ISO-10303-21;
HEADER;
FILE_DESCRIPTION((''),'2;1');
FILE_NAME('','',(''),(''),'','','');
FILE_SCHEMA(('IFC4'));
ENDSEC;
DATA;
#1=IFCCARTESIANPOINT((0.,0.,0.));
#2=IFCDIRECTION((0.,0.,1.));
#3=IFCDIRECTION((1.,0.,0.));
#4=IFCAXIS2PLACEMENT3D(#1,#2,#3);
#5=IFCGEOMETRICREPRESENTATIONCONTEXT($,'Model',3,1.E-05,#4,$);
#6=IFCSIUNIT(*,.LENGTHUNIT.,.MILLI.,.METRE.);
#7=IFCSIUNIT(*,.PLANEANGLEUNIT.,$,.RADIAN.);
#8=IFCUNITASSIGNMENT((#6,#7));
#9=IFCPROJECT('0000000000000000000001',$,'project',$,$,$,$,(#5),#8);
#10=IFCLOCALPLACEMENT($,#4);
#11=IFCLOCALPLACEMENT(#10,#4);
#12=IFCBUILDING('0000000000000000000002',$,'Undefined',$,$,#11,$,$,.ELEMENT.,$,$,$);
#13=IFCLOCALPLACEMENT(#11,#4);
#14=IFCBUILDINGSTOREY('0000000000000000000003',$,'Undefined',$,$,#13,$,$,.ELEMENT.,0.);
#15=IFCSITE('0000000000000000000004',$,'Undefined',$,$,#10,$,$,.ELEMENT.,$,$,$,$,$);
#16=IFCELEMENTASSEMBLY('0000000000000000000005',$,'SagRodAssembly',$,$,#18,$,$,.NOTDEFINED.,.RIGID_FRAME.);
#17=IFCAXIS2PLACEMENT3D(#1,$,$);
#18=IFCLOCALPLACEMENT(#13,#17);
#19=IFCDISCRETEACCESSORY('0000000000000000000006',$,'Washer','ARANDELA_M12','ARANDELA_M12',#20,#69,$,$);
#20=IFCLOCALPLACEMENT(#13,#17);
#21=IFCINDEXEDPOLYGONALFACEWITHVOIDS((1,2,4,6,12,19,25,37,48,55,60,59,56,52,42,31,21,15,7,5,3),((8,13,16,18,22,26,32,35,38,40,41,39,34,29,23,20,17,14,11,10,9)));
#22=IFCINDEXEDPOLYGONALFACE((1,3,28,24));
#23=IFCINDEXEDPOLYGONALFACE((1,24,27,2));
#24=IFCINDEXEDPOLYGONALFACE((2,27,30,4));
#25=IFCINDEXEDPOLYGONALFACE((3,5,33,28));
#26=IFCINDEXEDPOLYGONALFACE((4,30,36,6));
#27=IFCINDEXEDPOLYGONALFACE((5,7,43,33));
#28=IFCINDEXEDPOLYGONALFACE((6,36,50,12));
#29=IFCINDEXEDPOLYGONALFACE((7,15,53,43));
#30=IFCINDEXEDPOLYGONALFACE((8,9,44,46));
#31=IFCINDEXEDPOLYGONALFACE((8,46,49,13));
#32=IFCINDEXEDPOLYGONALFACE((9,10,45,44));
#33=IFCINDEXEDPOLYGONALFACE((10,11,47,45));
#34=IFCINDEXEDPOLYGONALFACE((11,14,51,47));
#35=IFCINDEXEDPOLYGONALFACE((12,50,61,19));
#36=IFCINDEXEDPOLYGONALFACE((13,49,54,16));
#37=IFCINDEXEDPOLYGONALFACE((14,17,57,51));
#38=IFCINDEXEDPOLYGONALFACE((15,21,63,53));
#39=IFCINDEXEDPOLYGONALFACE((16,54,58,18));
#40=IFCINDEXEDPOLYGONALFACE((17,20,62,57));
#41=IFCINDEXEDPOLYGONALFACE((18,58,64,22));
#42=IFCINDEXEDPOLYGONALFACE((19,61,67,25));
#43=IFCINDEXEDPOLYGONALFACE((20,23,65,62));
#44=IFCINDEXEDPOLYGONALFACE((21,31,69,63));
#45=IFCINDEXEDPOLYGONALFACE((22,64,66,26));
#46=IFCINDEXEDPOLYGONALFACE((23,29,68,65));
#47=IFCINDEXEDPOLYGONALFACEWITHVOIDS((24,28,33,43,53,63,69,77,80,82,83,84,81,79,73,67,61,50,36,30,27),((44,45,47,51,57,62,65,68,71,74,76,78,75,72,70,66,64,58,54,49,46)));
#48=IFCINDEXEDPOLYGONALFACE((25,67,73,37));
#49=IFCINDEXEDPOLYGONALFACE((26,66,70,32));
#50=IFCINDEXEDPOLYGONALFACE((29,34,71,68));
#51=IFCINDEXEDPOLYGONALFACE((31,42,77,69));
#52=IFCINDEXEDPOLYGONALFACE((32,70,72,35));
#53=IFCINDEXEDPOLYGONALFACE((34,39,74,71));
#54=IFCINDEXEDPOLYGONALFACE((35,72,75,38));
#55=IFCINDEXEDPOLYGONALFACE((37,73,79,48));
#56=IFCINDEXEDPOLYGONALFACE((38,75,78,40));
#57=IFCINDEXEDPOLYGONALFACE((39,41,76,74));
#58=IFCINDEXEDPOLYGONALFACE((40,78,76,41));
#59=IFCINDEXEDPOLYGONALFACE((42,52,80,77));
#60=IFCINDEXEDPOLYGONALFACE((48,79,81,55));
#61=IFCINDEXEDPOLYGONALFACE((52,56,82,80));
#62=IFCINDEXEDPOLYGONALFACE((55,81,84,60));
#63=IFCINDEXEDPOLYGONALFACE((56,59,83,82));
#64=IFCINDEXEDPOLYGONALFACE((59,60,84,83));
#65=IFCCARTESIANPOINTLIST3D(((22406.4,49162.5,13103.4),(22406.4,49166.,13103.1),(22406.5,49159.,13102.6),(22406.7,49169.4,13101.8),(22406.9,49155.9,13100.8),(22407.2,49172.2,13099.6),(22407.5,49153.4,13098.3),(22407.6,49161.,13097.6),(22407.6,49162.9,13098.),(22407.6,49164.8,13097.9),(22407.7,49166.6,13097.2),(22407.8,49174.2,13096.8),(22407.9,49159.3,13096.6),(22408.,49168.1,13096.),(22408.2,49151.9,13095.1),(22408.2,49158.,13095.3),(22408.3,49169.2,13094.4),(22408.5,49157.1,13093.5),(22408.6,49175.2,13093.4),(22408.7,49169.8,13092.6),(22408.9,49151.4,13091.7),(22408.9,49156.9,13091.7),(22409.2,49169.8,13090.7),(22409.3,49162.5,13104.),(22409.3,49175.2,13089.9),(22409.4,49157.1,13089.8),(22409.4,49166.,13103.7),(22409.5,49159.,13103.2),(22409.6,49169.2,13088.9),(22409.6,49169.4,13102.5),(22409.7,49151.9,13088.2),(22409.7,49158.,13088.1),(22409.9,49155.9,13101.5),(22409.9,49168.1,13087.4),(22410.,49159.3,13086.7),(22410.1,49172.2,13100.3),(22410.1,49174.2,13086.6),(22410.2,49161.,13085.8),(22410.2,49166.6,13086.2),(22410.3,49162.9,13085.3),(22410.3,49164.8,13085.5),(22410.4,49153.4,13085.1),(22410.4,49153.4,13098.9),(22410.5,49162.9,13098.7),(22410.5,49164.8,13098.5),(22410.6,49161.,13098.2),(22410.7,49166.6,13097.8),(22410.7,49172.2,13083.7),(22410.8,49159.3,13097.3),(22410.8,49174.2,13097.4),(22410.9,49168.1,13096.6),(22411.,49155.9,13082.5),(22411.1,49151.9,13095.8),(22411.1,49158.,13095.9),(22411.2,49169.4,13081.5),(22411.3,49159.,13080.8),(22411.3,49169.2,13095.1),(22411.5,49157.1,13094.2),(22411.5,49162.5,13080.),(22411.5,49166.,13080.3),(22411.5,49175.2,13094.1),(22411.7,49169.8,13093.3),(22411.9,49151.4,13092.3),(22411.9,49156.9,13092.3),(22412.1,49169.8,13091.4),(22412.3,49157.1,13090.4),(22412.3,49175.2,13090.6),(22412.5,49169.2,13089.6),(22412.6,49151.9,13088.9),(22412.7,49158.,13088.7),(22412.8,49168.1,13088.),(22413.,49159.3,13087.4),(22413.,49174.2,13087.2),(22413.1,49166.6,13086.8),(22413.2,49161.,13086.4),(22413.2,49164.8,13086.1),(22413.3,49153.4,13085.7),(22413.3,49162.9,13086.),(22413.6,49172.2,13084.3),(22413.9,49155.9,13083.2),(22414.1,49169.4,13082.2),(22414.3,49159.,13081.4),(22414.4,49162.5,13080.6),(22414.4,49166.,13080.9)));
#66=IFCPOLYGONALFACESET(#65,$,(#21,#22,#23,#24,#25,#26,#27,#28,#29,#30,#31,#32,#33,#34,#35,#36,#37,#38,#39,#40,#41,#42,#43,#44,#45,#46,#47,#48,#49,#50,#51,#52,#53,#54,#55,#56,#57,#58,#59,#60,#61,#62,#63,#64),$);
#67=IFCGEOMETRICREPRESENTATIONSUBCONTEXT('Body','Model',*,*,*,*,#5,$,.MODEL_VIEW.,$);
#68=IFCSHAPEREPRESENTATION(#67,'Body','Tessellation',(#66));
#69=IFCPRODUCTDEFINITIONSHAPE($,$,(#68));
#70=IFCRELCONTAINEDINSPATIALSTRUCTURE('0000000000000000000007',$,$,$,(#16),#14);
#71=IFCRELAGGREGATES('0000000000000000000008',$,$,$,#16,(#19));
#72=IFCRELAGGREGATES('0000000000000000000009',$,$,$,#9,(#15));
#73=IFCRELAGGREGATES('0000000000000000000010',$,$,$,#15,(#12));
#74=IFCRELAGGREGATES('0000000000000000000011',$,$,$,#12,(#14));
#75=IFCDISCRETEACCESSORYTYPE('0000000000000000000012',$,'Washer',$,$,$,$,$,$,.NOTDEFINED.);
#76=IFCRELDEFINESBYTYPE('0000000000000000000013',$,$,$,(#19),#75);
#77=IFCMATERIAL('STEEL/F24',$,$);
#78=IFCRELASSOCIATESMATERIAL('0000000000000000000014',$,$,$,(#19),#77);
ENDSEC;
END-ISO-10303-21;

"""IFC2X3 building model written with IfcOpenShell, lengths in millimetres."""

from ifc_helpers import new_model, si_unit, frame, origin_with_axes, origin_2d_with_axis, place, context, subcontext, project, spatial, hollow_circle, extrude, material, type_object, element, aggregate, save


model = new_model("IFC2X3")

# Units and contexts
model_context = context("Model", 3, precision=1e-05, world=origin_with_axes())
body_context = subcontext(model_context, "Body", "Model", "MODEL_VIEW")
ifc_project = project(units=[si_unit("LENGTHUNIT", "METRE", prefix="MILLI"), si_unit("PLANEANGLEUNIT", "RADIAN")], contexts=[model_context])

# Site, building, storey
site_placement = place(None, origin_with_axes())
site = spatial("IfcSite", under=ifc_project, at=site_placement, Name="Undefined", CompositionType="ELEMENT")
building_placement = place(site_placement, origin_with_axes())
building = spatial("IfcBuilding", under=site, at=building_placement, Name="Undefined", CompositionType="ELEMENT")
storey_placement = place(building_placement, origin_with_axes())
storey = spatial("IfcBuildingStorey", under=building, at=storey_placement, Name="Undefined", CompositionType="ELEMENT", Elevation=0.0)

# Shared definitions
ifc_material = material(Name="STEEL/F24")

# Element assembly
assembly_1_placement = place(storey_placement, origin_with_axes())
assembly_1 = element("IfcElementAssembly", 1, at=assembly_1_placement, inside=storey, Name="SagRodAssembly", AssemblyPlace="NOTDEFINED", PredefinedType="RIGID_FRAME")

# Discrete accessory
discrete_accessory_type_1 = type_object("IfcDiscreteAccessoryType", Name="Washer")
discrete_accessory_1_placement = place(assembly_1_placement, frame((22408.9, 49163.4, 13091.7), z_axis=(-0.214887, 0.0, 0.976639), x_axis=(0.976639, 0.0, 0.214887)))
discrete_accessory_1 = element("IfcDiscreteAccessory", 2, at=discrete_accessory_1_placement, type_object=discrete_accessory_type_1, material=ifc_material, Name="Washer", Description="ARANDELA_M12", ObjectType="ARANDELA_M12", context=body_context, shape_type="SweptSolid", body=[
    extrude(hollow_circle(Radius=12.0, WallThickness=5.5, at=origin_2d_with_axis()), frame((3.0, 0.0, 0.0), z_axis=(-1.0, 0.0, 0.0), x_axis=(0.0, -1.0, 0.0)), (0.0, 0.0, 1.0), 3.0),
])
aggregate(assembly_1, [discrete_accessory_1])

save(model, "model.ifc")
